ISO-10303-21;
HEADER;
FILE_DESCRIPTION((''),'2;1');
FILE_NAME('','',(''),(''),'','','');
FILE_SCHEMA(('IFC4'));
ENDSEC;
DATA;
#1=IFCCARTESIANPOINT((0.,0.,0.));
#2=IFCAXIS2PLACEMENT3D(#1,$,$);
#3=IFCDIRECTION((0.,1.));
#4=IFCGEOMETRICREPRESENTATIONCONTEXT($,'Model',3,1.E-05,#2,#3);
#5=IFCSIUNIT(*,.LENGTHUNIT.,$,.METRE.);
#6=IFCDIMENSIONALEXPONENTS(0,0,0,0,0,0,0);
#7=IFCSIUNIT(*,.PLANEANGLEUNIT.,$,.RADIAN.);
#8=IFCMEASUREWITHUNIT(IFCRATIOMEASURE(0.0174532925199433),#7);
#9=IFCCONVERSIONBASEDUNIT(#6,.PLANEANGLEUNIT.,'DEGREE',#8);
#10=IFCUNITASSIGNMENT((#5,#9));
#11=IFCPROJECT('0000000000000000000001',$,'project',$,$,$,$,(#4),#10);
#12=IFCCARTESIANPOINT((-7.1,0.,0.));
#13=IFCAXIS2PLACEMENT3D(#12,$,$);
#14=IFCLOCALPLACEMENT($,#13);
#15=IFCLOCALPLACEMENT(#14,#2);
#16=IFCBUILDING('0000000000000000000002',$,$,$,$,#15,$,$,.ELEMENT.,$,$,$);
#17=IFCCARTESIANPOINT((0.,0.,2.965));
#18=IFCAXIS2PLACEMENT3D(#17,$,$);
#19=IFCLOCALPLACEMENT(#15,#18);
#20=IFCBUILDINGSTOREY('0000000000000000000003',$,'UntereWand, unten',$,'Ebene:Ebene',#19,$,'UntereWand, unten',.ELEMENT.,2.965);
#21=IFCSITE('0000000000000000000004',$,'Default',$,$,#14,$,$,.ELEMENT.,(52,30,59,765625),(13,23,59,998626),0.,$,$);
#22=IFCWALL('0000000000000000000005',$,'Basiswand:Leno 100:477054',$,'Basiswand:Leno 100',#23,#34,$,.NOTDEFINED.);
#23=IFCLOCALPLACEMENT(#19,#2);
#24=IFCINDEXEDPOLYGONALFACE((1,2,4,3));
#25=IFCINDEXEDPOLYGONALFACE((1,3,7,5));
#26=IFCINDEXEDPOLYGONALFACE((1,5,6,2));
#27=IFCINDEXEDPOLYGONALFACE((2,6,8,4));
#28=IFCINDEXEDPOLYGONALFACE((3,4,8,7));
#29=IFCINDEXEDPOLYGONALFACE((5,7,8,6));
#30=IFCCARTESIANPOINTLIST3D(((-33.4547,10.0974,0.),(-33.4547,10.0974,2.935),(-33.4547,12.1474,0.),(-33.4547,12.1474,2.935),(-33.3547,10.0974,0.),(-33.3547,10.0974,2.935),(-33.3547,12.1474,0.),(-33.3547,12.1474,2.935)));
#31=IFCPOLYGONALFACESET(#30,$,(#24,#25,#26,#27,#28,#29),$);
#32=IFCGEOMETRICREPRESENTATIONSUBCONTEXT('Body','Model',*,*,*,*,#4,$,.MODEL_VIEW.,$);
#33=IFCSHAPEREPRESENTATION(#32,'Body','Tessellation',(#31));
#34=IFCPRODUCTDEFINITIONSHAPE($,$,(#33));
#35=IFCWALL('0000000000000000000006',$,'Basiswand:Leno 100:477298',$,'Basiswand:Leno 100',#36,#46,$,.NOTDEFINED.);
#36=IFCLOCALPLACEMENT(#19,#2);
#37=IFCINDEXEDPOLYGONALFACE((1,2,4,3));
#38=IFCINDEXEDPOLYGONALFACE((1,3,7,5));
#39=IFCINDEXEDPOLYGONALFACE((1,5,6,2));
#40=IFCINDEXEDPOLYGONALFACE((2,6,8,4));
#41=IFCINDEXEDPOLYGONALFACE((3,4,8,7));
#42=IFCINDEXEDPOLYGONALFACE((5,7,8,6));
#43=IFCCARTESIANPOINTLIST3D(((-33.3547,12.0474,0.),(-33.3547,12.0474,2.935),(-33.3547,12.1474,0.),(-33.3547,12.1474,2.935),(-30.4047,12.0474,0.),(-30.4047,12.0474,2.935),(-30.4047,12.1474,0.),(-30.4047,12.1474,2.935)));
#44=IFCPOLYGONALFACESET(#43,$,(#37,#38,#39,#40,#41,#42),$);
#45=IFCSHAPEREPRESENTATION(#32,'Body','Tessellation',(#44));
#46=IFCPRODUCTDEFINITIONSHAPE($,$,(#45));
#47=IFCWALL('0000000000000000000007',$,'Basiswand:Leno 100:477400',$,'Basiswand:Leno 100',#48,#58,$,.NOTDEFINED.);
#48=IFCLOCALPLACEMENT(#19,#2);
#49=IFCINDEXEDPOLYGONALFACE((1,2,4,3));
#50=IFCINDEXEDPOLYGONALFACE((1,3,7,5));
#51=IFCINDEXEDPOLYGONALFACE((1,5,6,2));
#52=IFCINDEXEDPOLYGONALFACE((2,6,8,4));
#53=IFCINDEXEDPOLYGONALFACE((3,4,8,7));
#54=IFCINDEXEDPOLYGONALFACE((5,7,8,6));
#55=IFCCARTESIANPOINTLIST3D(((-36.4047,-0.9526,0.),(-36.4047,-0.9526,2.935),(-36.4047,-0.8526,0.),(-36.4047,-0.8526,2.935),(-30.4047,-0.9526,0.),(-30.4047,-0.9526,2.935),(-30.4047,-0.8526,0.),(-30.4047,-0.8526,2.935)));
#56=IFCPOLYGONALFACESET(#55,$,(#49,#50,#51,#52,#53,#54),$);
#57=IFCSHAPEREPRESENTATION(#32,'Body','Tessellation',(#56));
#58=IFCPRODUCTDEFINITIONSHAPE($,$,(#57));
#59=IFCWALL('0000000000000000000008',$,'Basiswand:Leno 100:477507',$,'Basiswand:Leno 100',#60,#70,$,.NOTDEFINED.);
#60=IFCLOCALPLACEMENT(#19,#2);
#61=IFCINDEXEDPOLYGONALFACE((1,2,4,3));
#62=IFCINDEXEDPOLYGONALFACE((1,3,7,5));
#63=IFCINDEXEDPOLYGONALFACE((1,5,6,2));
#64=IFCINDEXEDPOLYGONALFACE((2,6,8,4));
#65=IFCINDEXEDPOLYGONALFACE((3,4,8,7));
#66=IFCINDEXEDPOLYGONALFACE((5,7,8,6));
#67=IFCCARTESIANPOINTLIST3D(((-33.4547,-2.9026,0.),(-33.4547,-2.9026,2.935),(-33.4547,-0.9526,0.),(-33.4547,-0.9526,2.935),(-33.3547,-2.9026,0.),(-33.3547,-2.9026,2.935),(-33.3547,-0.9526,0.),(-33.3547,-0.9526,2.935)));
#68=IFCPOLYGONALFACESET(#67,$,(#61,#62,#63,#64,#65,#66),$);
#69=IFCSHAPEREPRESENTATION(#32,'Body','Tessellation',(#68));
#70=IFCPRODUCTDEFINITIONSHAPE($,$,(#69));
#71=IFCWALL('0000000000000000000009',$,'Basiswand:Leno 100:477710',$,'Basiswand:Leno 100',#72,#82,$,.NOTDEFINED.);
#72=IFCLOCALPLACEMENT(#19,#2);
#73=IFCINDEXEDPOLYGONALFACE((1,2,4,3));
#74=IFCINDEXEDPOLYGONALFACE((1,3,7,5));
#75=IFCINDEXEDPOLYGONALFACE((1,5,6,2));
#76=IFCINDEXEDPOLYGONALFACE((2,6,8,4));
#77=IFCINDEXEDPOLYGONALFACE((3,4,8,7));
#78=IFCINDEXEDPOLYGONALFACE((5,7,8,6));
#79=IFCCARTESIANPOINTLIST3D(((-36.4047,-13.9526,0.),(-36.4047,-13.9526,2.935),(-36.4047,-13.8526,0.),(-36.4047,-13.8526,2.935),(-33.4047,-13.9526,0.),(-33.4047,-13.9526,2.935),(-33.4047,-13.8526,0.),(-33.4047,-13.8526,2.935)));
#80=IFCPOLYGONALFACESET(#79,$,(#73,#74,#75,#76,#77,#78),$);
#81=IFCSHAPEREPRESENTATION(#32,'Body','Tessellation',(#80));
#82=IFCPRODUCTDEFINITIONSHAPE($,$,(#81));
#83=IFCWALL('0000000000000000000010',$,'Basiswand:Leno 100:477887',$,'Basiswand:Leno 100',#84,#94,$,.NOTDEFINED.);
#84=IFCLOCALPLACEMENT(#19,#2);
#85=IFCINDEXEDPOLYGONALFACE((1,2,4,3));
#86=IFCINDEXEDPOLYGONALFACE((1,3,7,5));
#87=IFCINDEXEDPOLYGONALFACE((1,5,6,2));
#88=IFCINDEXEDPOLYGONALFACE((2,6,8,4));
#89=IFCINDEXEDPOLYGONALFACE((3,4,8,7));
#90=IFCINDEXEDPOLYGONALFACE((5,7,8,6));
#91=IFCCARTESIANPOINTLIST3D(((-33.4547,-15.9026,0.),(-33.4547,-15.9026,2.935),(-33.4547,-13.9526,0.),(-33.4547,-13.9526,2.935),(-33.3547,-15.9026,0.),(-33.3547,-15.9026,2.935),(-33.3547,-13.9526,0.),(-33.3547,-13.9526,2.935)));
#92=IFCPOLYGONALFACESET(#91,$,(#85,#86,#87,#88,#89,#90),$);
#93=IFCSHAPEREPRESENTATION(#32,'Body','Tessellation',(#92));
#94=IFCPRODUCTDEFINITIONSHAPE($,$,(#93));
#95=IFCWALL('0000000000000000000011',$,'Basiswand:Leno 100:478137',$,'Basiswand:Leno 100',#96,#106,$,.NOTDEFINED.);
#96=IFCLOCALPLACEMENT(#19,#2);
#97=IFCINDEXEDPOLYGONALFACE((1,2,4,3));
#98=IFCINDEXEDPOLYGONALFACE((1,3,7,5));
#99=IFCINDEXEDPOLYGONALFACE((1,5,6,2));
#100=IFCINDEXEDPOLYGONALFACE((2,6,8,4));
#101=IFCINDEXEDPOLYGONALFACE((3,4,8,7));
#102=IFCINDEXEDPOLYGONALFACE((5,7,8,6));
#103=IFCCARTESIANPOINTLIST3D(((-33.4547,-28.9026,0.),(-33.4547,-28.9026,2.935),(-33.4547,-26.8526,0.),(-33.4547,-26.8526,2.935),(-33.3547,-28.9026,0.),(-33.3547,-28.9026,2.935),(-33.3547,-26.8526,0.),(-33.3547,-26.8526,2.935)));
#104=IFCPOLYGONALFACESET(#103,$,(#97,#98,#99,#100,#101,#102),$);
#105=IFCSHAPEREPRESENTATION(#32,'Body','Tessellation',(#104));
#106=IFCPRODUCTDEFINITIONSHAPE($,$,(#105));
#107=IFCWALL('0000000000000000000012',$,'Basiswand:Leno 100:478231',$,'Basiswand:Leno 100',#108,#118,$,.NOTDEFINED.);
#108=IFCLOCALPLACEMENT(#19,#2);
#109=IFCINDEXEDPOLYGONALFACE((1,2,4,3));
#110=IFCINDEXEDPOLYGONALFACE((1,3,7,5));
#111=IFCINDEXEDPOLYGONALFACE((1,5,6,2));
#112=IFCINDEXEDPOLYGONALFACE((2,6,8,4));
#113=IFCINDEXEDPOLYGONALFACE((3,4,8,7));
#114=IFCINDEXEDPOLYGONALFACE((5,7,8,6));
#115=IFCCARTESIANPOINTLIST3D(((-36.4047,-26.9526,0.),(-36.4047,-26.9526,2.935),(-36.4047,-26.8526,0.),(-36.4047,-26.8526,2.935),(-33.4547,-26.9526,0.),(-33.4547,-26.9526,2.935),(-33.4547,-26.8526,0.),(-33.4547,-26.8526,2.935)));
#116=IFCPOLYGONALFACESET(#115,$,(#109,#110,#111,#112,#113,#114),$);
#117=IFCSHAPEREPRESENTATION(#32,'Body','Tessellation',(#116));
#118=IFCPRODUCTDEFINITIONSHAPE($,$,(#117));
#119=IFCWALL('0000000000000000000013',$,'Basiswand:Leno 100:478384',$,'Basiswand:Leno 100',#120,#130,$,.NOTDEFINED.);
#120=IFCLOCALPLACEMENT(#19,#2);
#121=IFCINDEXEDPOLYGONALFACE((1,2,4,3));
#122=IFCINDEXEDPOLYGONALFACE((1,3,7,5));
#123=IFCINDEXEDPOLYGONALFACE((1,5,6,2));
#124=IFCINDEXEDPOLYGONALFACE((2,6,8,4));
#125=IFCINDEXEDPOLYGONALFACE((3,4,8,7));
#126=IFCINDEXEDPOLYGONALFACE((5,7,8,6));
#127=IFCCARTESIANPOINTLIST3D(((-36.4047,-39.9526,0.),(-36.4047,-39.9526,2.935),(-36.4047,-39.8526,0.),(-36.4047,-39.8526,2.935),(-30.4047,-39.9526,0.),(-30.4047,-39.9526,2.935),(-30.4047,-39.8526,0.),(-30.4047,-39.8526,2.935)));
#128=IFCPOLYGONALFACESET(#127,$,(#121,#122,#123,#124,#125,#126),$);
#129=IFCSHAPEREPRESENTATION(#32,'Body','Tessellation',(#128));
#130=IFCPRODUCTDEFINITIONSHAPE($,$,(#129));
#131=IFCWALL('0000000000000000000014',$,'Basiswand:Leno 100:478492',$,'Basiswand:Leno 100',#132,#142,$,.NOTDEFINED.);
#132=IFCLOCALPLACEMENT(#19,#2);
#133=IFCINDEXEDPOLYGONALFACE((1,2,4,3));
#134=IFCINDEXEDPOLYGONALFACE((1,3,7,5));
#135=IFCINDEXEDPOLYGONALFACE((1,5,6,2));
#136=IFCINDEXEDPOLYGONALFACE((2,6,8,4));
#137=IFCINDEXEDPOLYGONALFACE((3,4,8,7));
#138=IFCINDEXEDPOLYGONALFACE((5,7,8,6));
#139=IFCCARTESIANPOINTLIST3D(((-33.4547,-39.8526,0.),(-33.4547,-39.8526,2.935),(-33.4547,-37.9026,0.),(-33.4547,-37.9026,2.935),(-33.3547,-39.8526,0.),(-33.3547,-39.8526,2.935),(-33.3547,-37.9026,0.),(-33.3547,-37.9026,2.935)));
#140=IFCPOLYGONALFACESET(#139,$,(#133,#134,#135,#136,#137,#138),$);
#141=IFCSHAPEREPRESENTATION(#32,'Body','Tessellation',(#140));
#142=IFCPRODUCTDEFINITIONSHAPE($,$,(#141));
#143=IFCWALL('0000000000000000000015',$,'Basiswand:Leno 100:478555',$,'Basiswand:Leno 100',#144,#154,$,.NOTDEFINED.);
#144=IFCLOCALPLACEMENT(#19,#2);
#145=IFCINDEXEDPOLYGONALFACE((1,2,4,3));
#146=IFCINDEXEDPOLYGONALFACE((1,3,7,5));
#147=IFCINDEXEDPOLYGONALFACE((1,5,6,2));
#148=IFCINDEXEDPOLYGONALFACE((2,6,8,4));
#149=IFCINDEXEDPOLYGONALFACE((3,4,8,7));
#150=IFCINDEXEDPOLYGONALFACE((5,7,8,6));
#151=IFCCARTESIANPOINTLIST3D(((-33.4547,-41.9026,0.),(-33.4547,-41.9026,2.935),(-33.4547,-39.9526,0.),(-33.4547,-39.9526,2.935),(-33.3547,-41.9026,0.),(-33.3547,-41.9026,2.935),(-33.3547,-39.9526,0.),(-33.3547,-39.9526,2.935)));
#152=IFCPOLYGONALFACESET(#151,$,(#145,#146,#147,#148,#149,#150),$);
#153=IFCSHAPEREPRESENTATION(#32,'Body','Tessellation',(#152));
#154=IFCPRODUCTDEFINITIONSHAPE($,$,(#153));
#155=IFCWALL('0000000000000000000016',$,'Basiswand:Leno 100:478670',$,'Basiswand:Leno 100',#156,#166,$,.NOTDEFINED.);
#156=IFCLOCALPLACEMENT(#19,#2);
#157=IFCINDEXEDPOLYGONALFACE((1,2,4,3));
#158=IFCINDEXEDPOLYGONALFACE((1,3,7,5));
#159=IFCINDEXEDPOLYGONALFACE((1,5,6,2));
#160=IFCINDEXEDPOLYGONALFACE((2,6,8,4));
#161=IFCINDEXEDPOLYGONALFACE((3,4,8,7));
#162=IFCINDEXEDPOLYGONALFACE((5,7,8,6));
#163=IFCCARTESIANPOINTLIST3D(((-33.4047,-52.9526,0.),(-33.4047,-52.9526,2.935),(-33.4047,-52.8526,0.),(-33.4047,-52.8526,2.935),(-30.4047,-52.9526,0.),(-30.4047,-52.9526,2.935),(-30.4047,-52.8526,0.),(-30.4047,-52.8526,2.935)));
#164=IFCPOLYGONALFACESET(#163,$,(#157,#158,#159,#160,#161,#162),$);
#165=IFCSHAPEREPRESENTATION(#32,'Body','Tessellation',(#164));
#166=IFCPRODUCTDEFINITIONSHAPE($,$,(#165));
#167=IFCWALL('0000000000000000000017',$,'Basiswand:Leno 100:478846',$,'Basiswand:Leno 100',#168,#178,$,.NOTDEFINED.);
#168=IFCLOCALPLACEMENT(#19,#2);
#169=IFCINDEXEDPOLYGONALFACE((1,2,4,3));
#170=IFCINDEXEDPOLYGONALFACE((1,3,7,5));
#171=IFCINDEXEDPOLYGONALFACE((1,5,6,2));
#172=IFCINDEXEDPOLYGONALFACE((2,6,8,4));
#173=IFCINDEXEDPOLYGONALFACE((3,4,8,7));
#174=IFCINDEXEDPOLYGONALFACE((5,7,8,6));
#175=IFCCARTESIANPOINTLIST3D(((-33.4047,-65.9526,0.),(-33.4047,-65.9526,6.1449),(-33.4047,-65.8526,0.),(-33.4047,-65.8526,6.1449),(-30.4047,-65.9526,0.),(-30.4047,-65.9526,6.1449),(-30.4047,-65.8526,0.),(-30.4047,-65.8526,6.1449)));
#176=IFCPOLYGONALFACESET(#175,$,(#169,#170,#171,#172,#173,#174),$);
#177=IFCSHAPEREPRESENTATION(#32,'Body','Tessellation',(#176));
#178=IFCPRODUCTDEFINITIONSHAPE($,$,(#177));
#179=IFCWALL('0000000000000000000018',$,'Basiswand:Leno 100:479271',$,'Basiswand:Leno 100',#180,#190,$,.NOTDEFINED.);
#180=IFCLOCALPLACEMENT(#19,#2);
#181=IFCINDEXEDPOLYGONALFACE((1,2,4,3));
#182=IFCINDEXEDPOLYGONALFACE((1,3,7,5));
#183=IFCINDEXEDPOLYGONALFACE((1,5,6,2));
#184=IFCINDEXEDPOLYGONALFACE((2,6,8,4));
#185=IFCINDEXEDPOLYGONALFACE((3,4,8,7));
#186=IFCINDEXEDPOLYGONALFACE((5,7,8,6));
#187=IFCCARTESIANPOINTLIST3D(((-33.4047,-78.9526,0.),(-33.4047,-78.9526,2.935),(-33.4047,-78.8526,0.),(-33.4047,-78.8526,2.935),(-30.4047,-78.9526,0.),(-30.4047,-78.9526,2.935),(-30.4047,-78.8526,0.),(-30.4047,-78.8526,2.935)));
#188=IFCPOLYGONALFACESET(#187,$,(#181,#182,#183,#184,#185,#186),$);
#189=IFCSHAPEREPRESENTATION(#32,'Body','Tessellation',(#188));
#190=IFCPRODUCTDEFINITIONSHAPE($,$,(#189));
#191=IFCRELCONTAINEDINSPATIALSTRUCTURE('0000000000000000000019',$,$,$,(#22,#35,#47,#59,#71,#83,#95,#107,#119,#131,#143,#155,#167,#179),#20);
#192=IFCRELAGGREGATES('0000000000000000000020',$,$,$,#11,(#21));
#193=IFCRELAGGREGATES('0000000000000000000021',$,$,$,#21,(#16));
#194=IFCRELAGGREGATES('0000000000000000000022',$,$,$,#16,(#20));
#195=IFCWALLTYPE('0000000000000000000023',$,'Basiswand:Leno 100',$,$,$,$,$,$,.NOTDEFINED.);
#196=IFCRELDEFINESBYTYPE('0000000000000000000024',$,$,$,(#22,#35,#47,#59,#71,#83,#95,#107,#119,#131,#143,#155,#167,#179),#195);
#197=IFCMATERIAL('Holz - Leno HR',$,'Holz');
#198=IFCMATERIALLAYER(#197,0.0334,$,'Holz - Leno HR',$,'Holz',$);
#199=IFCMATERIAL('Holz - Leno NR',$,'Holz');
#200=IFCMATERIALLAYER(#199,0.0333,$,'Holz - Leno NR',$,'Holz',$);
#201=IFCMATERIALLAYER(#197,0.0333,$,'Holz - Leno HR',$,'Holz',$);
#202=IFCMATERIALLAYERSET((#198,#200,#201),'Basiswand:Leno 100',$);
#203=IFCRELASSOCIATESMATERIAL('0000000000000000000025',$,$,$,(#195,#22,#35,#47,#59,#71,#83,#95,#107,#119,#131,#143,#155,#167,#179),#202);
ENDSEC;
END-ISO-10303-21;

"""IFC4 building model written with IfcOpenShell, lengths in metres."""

from ifc_helpers import new_model, entity, si_unit, converted_unit, direction, frame, origin, place, context, subcontext, project, spatial, indexed_curve, outline, extrude, material, layer, layer_set, type_object, element, save


model = new_model("IFC4")

# Units and contexts
model_context = context("Model", 3, precision=1e-05, world=origin(), true_north=direction((0.0, 1.0)))
body_context = subcontext(model_context, "Body", "Model", "MODEL_VIEW")
ifc_project = project(units=[si_unit("LENGTHUNIT", "METRE"), converted_unit("PLANEANGLEUNIT", "DEGREE", entity("IfcRatioMeasure", 0.0174532925199433), si_unit("PLANEANGLEUNIT", "RADIAN"), dimensions=[0, 0, 0, 0, 0, 0, 0])], contexts=[model_context])

# Site, building, storey
site_placement = place(None, frame((-7.1, 0.0, 0.0)))
site = spatial("IfcSite", under=ifc_project, at=site_placement, Name="Default", CompositionType="ELEMENT", RefLatitude=(52, 30, 59, 765625), RefLongitude=(13, 23, 59, 998626), RefElevation=0.0)
building_placement = place(site_placement, origin())
building = spatial("IfcBuilding", under=site, at=building_placement, CompositionType="ELEMENT")
storey_placement = place(building_placement, frame((0.0, 0.0, 2.965)))
storey = spatial("IfcBuildingStorey", under=building, at=storey_placement, Name="UntereWand, unten", ObjectType="Ebene:Ebene", LongName="UntereWand, unten", CompositionType="ELEMENT", Elevation=2.965)

# Walls
ifc_material_1 = material(Name="Holz - Leno HR", Category="Holz")
ifc_layer_1 = layer(ifc_material_1, 0.0334, Name="Holz - Leno HR", Category="Holz")
ifc_material_2 = material(Name="Holz - Leno NR", Category="Holz")
ifc_layer_2 = layer(ifc_material_2, 0.0333, Name="Holz - Leno NR", Category="Holz")
ifc_layer_3 = layer(ifc_material_1, 0.0333, Name="Holz - Leno HR", Category="Holz")
ifc_layer_set = layer_set([ifc_layer_1, ifc_layer_2, ifc_layer_3], Name="Basiswand:Leno 100")
wall_type = type_object("IfcWallType", Name="Basiswand:Leno 100", PredefinedType="NOTDEFINED", material=ifc_layer_set)
wall_1_placement = place(storey_placement, frame((-33.4047, 10.0974, 0.0), z_axis=(0.0, 0.0, 1.0), x_axis=(0.0, 1.0, 0.0)))
element("IfcWall", 1, at=wall_1_placement, inside=storey, type_object=wall_type, material=ifc_layer_set, Name="Basiswand:Leno 100:477054", ObjectType="Basiswand:Leno 100", PredefinedType="NOTDEFINED", context=body_context, shape_type="SweptSolid", body=[
    extrude(outline(indexed_curve([(2.05, 0.05), (0.0, 0.05), (0.0, -0.05), (2.05, -0.05), (2.05, 0.05)], self_intersect=False)), origin(), (0.0, 0.0, 1.0), 2.935),
])
wall_2_placement = place(storey_placement, frame((-30.4047, 12.0974, 0.0), z_axis=(0.0, 0.0, 1.0), x_axis=(-1.0, 0.0, 0.0)))
element("IfcWall", 2, at=wall_2_placement, inside=storey, type_object=wall_type, material=ifc_layer_set, Name="Basiswand:Leno 100:477298", ObjectType="Basiswand:Leno 100", PredefinedType="NOTDEFINED", context=body_context, shape_type="SweptSolid", body=[
    extrude(outline(indexed_curve([(2.95, 0.05), (0.0, 0.05), (0.0, -0.05), (2.95, -0.05), (2.95, 0.05)], self_intersect=False)), origin(), (0.0, 0.0, 1.0), 2.935),
])
wall_3_placement = place(storey_placement, frame((-30.4047, -0.9026, 0.0), z_axis=(0.0, 0.0, 1.0), x_axis=(-1.0, 0.0, 0.0)))
element("IfcWall", 3, at=wall_3_placement, inside=storey, type_object=wall_type, material=ifc_layer_set, Name="Basiswand:Leno 100:477400", ObjectType="Basiswand:Leno 100", PredefinedType="NOTDEFINED", context=body_context, shape_type="SweptSolid", body=[
    extrude(outline(indexed_curve([(6.0, 0.05), (0.0, 0.05), (0.0, -0.05), (6.0, -0.05), (6.0, 0.05)], self_intersect=False)), origin(), (0.0, 0.0, 1.0), 2.935),
])
wall_4_placement = place(storey_placement, frame((-33.4047, -2.9026, 0.0), z_axis=(0.0, 0.0, 1.0), x_axis=(0.0, 1.0, 0.0)))
element("IfcWall", 4, at=wall_4_placement, inside=storey, type_object=wall_type, material=ifc_layer_set, Name="Basiswand:Leno 100:477507", ObjectType="Basiswand:Leno 100", PredefinedType="NOTDEFINED", context=body_context, shape_type="SweptSolid", body=[
    extrude(outline(indexed_curve([(1.95, 0.05), (0.0, 0.05), (0.0, -0.05), (1.95, -0.05), (1.95, 0.05)], self_intersect=False)), origin(), (0.0, 0.0, 1.0), 2.935),
])
wall_5_placement = place(storey_placement, frame((-36.4047, -13.9026, 0.0)))
element("IfcWall", 5, at=wall_5_placement, inside=storey, type_object=wall_type, material=ifc_layer_set, Name="Basiswand:Leno 100:477710", ObjectType="Basiswand:Leno 100", PredefinedType="NOTDEFINED", context=body_context, shape_type="SweptSolid", body=[
    extrude(outline(indexed_curve([(3.0, 0.05), (0.0, 0.05), (0.0, -0.05), (3.0, -0.05), (3.0, 0.05)], self_intersect=False)), origin(), (0.0, 0.0, 1.0), 2.935),
])
wall_6_placement = place(storey_placement, frame((-33.4047, -15.9026, 0.0), z_axis=(0.0, 0.0, 1.0), x_axis=(0.0, 1.0, 0.0)))
element("IfcWall", 6, at=wall_6_placement, inside=storey, type_object=wall_type, material=ifc_layer_set, Name="Basiswand:Leno 100:477887", ObjectType="Basiswand:Leno 100", PredefinedType="NOTDEFINED", context=body_context, shape_type="SweptSolid", body=[
    extrude(outline(indexed_curve([(1.95, 0.05), (0.0, 0.05), (0.0, -0.05), (1.95, -0.05), (1.95, 0.05)], self_intersect=False)), origin(), (0.0, 0.0, 1.0), 2.935),
])
wall_7_placement = place(storey_placement, frame((-33.4047, -28.9026, 0.0), z_axis=(0.0, 0.0, 1.0), x_axis=(0.0, 1.0, 0.0)))
element("IfcWall", 7, at=wall_7_placement, inside=storey, type_object=wall_type, material=ifc_layer_set, Name="Basiswand:Leno 100:478137", ObjectType="Basiswand:Leno 100", PredefinedType="NOTDEFINED", context=body_context, shape_type="SweptSolid", body=[
    extrude(outline(indexed_curve([(2.05, 0.05), (0.0, 0.05), (0.0, -0.05), (2.05, -0.05), (2.05, 0.05)], self_intersect=False)), origin(), (0.0, 0.0, 1.0), 2.935),
])
wall_8_placement = place(storey_placement, frame((-36.4047, -26.9026, 0.0)))
element("IfcWall", 8, at=wall_8_placement, inside=storey, type_object=wall_type, material=ifc_layer_set, Name="Basiswand:Leno 100:478231", ObjectType="Basiswand:Leno 100", PredefinedType="NOTDEFINED", context=body_context, shape_type="SweptSolid", body=[
    extrude(outline(indexed_curve([(2.95, 0.05), (0.0, 0.05), (0.0, -0.05), (2.95, -0.05), (2.95, 0.05)], self_intersect=False)), origin(), (0.0, 0.0, 1.0), 2.935),
])
wall_9_placement = place(storey_placement, frame((-36.4047, -39.9026, 0.0)))
element("IfcWall", 9, at=wall_9_placement, inside=storey, type_object=wall_type, material=ifc_layer_set, Name="Basiswand:Leno 100:478384", ObjectType="Basiswand:Leno 100", PredefinedType="NOTDEFINED", context=body_context, shape_type="SweptSolid", body=[
    extrude(outline(indexed_curve([(6.0, 0.05), (0.0, 0.05), (0.0, -0.05), (6.0, -0.05), (6.0, 0.05)], self_intersect=False)), origin(), (0.0, 0.0, 1.0), 2.935),
])
wall_10_placement = place(storey_placement, frame((-33.4047, -37.9026, 0.0), z_axis=(0.0, 0.0, 1.0), x_axis=(0.0, -1.0, 0.0)))
element("IfcWall", 10, at=wall_10_placement, inside=storey, type_object=wall_type, material=ifc_layer_set, Name="Basiswand:Leno 100:478492", ObjectType="Basiswand:Leno 100", PredefinedType="NOTDEFINED", context=body_context, shape_type="SweptSolid", body=[
    extrude(outline(indexed_curve([(1.95, 0.05), (0.0, 0.05), (0.0, -0.05), (1.95, -0.05), (1.95, 0.05)], self_intersect=False)), origin(), (0.0, 0.0, 1.0), 2.935),
])
wall_11_placement = place(storey_placement, frame((-33.4047, -41.9026, 0.0), z_axis=(0.0, 0.0, 1.0), x_axis=(0.0, 1.0, 0.0)))
element("IfcWall", 11, at=wall_11_placement, inside=storey, type_object=wall_type, material=ifc_layer_set, Name="Basiswand:Leno 100:478555", ObjectType="Basiswand:Leno 100", PredefinedType="NOTDEFINED", context=body_context, shape_type="SweptSolid", body=[
    extrude(outline(indexed_curve([(1.95, 0.05), (0.0, 0.05), (0.0, -0.05), (1.95, -0.05), (1.95, 0.05)], self_intersect=False)), origin(), (0.0, 0.0, 1.0), 2.935),
])
wall_12_placement = place(storey_placement, frame((-30.4047, -52.9026, 0.0), z_axis=(0.0, 0.0, 1.0), x_axis=(-1.0, 0.0, 0.0)))
element("IfcWall", 12, at=wall_12_placement, inside=storey, type_object=wall_type, material=ifc_layer_set, Name="Basiswand:Leno 100:478670", ObjectType="Basiswand:Leno 100", PredefinedType="NOTDEFINED", context=body_context, shape_type="SweptSolid", body=[
    extrude(outline(indexed_curve([(3.0, 0.05), (0.0, 0.05), (0.0, -0.05), (3.0, -0.05), (3.0, 0.05)], self_intersect=False)), origin(), (0.0, 0.0, 1.0), 2.935),
])
wall_13_placement = place(storey_placement, frame((-30.4047, -65.9026, 0.0), z_axis=(0.0, 0.0, 1.0), x_axis=(-1.0, 0.0, 0.0)))
element("IfcWall", 13, at=wall_13_placement, inside=storey, type_object=wall_type, material=ifc_layer_set, Name="Basiswand:Leno 100:478846", ObjectType="Basiswand:Leno 100", PredefinedType="NOTDEFINED", context=body_context, shape_type="SweptSolid", body=[
    extrude(outline(indexed_curve([(3.0, 0.05), (0.0, 0.05), (0.0, -0.05), (3.0, -0.05), (3.0, 0.05)], self_intersect=False)), origin(), (0.0, 0.0, 1.0), 6.1449),
])
wall_14_placement = place(storey_placement, frame((-30.4047, -78.9026, 0.0), z_axis=(0.0, 0.0, 1.0), x_axis=(-1.0, 0.0, 0.0)))
element("IfcWall", 14, at=wall_14_placement, inside=storey, type_object=wall_type, material=ifc_layer_set, Name="Basiswand:Leno 100:479271", ObjectType="Basiswand:Leno 100", PredefinedType="NOTDEFINED", context=body_context, shape_type="SweptSolid", body=[
    extrude(outline(indexed_curve([(3.0, 0.05), (0.0, 0.05), (0.0, -0.05), (3.0, -0.05), (3.0, 0.05)], self_intersect=False)), origin(), (0.0, 0.0, 1.0), 2.935),
])

save(model, "model.ifc")
